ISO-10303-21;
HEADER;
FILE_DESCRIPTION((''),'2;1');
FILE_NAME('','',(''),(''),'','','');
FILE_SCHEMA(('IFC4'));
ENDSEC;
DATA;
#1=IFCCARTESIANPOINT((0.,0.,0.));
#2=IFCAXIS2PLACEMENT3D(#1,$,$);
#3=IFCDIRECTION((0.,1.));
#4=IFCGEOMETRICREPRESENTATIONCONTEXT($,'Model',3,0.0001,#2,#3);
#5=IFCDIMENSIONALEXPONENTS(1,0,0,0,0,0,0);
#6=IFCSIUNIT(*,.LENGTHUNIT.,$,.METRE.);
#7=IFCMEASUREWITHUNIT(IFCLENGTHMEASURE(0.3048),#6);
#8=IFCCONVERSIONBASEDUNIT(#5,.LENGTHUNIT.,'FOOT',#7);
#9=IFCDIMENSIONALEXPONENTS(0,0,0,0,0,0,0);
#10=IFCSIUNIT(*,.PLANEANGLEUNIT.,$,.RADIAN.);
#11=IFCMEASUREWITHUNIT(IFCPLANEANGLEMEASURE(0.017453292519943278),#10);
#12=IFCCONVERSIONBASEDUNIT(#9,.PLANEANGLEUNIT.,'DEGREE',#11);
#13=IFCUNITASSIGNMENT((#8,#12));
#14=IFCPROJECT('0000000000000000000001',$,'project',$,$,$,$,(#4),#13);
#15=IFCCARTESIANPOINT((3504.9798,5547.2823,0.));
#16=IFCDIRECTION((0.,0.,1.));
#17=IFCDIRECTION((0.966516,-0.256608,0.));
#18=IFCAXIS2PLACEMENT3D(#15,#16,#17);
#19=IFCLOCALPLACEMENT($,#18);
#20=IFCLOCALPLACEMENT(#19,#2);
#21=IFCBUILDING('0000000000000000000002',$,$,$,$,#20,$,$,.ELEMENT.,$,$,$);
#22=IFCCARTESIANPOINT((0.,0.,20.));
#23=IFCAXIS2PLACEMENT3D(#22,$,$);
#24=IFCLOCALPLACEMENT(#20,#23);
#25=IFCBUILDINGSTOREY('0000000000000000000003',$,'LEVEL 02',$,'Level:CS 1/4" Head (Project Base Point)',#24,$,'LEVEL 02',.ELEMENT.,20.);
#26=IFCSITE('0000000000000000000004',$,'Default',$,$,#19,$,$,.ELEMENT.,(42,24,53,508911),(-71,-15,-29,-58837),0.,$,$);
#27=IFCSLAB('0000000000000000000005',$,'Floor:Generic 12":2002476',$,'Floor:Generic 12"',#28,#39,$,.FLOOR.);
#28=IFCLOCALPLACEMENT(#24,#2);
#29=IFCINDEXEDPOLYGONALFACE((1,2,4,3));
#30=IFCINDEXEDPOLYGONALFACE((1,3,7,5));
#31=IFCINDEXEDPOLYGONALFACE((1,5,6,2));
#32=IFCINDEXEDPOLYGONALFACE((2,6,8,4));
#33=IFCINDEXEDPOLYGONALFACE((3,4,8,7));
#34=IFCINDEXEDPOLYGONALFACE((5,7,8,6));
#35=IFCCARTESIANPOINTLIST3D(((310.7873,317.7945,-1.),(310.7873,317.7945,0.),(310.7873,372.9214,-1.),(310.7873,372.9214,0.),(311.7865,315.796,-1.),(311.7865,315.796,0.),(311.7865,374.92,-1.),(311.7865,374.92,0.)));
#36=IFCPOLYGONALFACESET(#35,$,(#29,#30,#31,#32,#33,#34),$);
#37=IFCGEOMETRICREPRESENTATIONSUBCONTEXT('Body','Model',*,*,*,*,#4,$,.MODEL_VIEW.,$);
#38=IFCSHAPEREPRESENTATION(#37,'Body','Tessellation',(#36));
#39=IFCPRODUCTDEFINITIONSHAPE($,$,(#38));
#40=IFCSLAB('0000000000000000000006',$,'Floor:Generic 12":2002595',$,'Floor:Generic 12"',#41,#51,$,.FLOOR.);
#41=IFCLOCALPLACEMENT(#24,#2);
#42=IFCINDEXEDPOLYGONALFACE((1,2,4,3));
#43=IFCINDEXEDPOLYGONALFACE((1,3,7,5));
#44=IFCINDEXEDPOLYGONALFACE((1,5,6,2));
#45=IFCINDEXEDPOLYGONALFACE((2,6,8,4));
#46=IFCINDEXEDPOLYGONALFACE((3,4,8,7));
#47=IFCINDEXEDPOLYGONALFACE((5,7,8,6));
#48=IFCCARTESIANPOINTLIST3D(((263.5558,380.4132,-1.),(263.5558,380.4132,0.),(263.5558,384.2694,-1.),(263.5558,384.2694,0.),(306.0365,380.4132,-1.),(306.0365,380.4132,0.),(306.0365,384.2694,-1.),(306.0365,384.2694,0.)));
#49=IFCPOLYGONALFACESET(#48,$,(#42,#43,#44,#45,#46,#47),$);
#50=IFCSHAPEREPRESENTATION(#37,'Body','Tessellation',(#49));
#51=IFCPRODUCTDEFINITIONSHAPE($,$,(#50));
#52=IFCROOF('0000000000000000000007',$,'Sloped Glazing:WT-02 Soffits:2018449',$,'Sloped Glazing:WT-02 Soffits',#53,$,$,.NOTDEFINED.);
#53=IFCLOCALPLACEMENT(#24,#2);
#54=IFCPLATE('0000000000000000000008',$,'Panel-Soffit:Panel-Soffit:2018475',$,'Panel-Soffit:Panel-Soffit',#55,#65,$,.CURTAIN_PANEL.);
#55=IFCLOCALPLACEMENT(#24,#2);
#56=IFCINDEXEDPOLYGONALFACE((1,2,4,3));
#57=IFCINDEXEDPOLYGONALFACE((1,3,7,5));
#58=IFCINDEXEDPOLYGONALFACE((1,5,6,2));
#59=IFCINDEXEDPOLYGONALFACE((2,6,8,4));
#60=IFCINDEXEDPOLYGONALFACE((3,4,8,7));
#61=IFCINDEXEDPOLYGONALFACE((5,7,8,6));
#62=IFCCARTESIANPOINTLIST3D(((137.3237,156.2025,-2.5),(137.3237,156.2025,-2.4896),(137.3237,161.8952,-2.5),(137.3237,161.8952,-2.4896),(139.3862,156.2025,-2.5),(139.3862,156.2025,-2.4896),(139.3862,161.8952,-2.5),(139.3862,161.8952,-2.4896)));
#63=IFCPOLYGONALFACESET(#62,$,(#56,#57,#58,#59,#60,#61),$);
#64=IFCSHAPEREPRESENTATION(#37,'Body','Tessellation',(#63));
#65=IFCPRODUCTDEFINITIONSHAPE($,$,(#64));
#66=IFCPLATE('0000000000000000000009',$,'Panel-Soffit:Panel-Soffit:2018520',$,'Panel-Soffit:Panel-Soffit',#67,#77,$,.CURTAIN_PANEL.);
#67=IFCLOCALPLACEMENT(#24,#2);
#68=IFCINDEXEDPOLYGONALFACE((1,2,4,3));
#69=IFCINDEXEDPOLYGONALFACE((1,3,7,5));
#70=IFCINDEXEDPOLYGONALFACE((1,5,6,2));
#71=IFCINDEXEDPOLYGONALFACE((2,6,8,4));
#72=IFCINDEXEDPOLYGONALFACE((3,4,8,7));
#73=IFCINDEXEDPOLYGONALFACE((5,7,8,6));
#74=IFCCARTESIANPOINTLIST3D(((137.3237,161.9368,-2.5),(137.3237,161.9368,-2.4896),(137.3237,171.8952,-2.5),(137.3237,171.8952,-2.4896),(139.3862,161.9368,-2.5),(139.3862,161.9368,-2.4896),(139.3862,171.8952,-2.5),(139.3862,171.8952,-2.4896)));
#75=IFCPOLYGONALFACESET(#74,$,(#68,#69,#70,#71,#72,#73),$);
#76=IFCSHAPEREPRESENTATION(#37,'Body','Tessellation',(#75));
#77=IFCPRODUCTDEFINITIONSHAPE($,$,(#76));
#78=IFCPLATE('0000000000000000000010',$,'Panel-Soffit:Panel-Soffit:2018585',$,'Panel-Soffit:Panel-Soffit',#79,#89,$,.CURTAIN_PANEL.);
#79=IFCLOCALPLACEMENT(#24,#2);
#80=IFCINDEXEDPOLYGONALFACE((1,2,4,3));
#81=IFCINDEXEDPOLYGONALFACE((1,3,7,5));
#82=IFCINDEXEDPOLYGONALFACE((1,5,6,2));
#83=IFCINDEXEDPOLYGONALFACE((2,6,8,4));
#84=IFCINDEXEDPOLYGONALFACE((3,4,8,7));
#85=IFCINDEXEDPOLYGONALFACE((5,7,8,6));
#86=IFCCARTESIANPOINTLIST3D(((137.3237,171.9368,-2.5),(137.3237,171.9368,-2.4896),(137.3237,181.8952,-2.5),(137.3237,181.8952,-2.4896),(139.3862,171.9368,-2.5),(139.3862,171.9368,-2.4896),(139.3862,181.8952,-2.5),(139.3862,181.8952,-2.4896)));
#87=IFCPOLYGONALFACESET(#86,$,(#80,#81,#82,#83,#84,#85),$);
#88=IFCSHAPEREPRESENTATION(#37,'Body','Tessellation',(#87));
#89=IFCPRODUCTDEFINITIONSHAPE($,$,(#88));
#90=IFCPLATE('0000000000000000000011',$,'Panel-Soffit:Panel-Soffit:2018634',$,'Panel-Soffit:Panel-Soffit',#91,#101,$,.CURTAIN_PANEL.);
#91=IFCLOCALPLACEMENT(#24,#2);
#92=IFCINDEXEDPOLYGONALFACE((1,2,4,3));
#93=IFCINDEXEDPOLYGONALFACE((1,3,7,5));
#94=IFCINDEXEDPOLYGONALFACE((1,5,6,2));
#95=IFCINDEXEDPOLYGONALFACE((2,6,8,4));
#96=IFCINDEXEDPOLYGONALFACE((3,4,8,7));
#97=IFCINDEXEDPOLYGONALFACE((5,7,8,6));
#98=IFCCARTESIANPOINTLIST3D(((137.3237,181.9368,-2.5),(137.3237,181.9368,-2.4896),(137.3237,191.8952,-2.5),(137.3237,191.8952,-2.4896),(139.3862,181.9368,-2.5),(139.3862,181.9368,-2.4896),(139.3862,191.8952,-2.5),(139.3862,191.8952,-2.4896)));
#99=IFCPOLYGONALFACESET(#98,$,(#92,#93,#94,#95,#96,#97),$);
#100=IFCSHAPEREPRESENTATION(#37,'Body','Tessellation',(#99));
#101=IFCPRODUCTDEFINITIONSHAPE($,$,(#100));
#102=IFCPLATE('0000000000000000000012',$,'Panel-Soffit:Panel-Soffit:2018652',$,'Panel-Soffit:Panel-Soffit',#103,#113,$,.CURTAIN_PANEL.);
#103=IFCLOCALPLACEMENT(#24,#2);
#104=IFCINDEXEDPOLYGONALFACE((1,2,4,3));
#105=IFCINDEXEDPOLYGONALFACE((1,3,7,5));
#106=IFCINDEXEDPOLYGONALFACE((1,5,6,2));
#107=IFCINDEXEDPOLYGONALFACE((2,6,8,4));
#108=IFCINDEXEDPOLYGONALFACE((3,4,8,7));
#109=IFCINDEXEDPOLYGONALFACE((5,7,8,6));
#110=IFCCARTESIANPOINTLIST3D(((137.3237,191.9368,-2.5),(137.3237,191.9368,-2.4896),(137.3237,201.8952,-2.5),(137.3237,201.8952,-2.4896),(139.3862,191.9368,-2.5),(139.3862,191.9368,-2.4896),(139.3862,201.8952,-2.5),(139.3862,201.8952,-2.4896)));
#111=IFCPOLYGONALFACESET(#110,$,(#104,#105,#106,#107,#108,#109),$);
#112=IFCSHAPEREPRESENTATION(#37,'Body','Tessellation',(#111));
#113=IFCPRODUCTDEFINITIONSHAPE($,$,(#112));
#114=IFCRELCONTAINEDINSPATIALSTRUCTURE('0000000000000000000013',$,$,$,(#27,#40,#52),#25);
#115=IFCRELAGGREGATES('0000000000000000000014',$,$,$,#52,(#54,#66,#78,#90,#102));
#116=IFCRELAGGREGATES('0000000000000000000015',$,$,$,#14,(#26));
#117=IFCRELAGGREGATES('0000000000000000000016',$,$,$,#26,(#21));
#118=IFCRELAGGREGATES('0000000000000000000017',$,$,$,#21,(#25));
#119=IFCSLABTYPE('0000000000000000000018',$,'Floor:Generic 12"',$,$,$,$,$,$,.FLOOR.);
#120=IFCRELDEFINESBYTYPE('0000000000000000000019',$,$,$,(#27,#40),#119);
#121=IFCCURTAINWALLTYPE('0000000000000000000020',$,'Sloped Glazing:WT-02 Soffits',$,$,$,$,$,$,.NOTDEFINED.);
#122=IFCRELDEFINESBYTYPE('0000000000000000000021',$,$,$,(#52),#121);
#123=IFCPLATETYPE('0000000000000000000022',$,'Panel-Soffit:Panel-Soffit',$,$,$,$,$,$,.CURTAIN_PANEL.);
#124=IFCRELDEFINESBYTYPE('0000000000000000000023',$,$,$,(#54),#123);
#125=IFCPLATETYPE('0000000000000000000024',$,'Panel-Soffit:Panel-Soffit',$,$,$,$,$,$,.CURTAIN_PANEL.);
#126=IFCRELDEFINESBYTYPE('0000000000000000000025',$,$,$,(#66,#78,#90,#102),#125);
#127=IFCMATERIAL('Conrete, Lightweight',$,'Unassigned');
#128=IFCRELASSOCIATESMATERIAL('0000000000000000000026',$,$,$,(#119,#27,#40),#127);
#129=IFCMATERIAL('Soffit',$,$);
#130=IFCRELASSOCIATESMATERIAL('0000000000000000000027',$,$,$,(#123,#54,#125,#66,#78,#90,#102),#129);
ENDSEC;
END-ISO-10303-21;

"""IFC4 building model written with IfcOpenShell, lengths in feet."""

from ifc_helpers import new_model, entity, si_unit, converted_unit, direction, frame, origin, place, context, subcontext, project, spatial, indexed_curve, outline, extrude, source, transform, mapped, material, type_object, type_shapes, element, aggregate, save


model = new_model("IFC4")

# Units and contexts
model_context = context("Model", 3, precision=0.0001, world=origin(), true_north=direction((0.0, 1.0)))
body_context = subcontext(model_context, "Body", "Model", "MODEL_VIEW")
ifc_project = project(units=[converted_unit("LENGTHUNIT", "FOOT", entity("IfcLengthMeasure", 0.3048), si_unit("LENGTHUNIT", "METRE"), dimensions=[1, 0, 0, 0, 0, 0, 0]), converted_unit("PLANEANGLEUNIT", "DEGREE", entity("IfcPlaneAngleMeasure", 0.017453292519943278), si_unit("PLANEANGLEUNIT", "RADIAN"), dimensions=[0, 0, 0, 0, 0, 0, 0])], contexts=[model_context])

# Site, building, storey
site_placement = place(None, frame((3504.9798, 5547.2823, 0.0), z_axis=(0.0, 0.0, 1.0), x_axis=(0.966516, -0.256608, 0.0)))
site = spatial("IfcSite", under=ifc_project, at=site_placement, Name="Default", CompositionType="ELEMENT", RefLatitude=(42, 24, 53, 508911), RefLongitude=(-71, -15, -29, -58837), RefElevation=0.0)
building_placement = place(site_placement, origin())
building = spatial("IfcBuilding", under=site, at=building_placement, CompositionType="ELEMENT")
storey_placement = place(building_placement, frame((0.0, 0.0, 20.0)))
storey = spatial("IfcBuildingStorey", under=building, at=storey_placement, Name="LEVEL 02", ObjectType="Level:CS 1/4\" Head (Project Base Point)", LongName="LEVEL 02", CompositionType="ELEMENT", Elevation=20.0)

# Shared definitions
curtain_wall_type_1 = type_object("IfcCurtainWallType", Name="Sloped Glazing:WT-02 Soffits", PredefinedType="NOTDEFINED")
ifc_material_1 = material(Name="Soffit")

# Shared definitions
ifc_material_2 = material(Name="Conrete, Lightweight", Category="Unassigned")
slab_type = type_object("IfcSlabType", Name="Floor:Generic 12\"", PredefinedType="FLOOR", material=ifc_material_2)

# Slabs
slab_1_placement = place(storey_placement, origin())
element("IfcSlab", 1, at=slab_1_placement, inside=storey, type_object=slab_type, material=ifc_material_2, Name="Floor:Generic 12\":2002476", ObjectType="Floor:Generic 12\"", PredefinedType="FLOOR", context=body_context, shape_type="SweptSolid", body=[
    extrude(outline(indexed_curve([(-27.5634, -0.4996), (27.5634, -0.4996), (29.562, 0.4996), (-29.562, 0.4996), (-27.5634, -0.4996)], self_intersect=False)), frame((311.2869, 345.358, 0.0), z_axis=(0.0, 0.0, -1.0), x_axis=(0.0, 1.0, 0.0)), (0.0, 0.0, 1.0), 1.0),
])
slab_2_placement = place(storey_placement, origin())
element("IfcSlab", 2, at=slab_2_placement, inside=storey, type_object=slab_type, material=ifc_material_2, Name="Floor:Generic 12\":2002595", ObjectType="Floor:Generic 12\"", PredefinedType="FLOOR", context=body_context, shape_type="SweptSolid", body=[
    extrude(outline(indexed_curve([(-1.9281, -21.2404), (1.9281, -21.2404), (1.9281, 21.2404), (-1.9281, 21.2404), (-1.9281, -21.2404)], self_intersect=False)), frame((284.7962, 382.3413, 0.0), z_axis=(0.0, 0.0, -1.0), x_axis=(0.0, 1.0, 0.0)), (0.0, 0.0, 1.0), 1.0),
])

# Roof, plates
roof_1_placement = place(storey_placement, frame((0.0, 0.0, -20.0)))
roof_1 = element("IfcRoof", 3, at=roof_1_placement, inside=storey, type_object=curtain_wall_type_1, Name="Sloped Glazing:WT-02 Soffits:2018449", ObjectType="Sloped Glazing:WT-02 Soffits", PredefinedType="NOTDEFINED")
plate_type_1 = type_object("IfcPlateType", Name="Panel-Soffit:Panel-Soffit", PredefinedType="CURTAIN_PANEL", material=ifc_material_1)
shared_shape_1 = source(origin(), body_context, "Body", "SweptSolid", [
    extrude(outline(indexed_curve([(-0.0052, -1.0313), (0.0052, -1.0313), (0.0052, 1.0313), (-0.0052, 1.0313), (-0.0052, -1.0313)], self_intersect=False)), frame((0.0, -0.0052, 0.0208), z_axis=(0.0, 0.0, 1.0), x_axis=(0.0, -1.0, 0.0)), (0.0, 0.0, 1.0), 5.6927),
])
type_shapes(plate_type_1, [shared_shape_1])
plate_1_placement = place(roof_1_placement, frame((138.355, 156.1816, 17.5), z_axis=(0.0, 1.0, 0.0), x_axis=(1.0, 0.0, 0.0)))
plate_1 = element("IfcPlate", 4, at=plate_1_placement, type_object=plate_type_1, material=ifc_material_1, Name="Panel-Soffit:Panel-Soffit:2018475", ObjectType="Panel-Soffit:Panel-Soffit", PredefinedType="CURTAIN_PANEL", context=body_context, shape_type="MappedRepresentation", body=[
    mapped(shared_shape_1, transform((0.0, 0.0, 0.0), scale=1.0)),
])
plate_type_2 = type_object("IfcPlateType", Name="Panel-Soffit:Panel-Soffit", PredefinedType="CURTAIN_PANEL", material=ifc_material_1)
shared_shape_2 = source(origin(), body_context, "Body", "SweptSolid", [
    extrude(outline(indexed_curve([(-0.0052, -1.0313), (0.0052, -1.0313), (0.0052, 1.0313), (-0.0052, 1.0313), (-0.0052, -1.0313)], self_intersect=False)), frame((0.0, -0.0052, 0.0208), z_axis=(0.0, 0.0, 1.0), x_axis=(0.0, -1.0, 0.0)), (0.0, 0.0, 1.0), 9.9583),
])
type_shapes(plate_type_2, [shared_shape_2])
plate_2_placement = place(roof_1_placement, frame((138.355, 161.916, 17.5), z_axis=(0.0, 1.0, 0.0), x_axis=(1.0, 0.0, 0.0)))
plate_2 = element("IfcPlate", 5, at=plate_2_placement, type_object=plate_type_2, material=ifc_material_1, Name="Panel-Soffit:Panel-Soffit:2018520", ObjectType="Panel-Soffit:Panel-Soffit", PredefinedType="CURTAIN_PANEL", context=body_context, shape_type="MappedRepresentation", body=[
    mapped(shared_shape_2, transform((0.0, 0.0, 0.0), scale=1.0)),
])
plate_3_placement = place(roof_1_placement, frame((138.355, 171.916, 17.5), z_axis=(0.0, 1.0, 0.0), x_axis=(1.0, 0.0, 0.0)))
plate_3 = element("IfcPlate", 6, at=plate_3_placement, type_object=plate_type_2, material=ifc_material_1, Name="Panel-Soffit:Panel-Soffit:2018585", ObjectType="Panel-Soffit:Panel-Soffit", PredefinedType="CURTAIN_PANEL", context=body_context, shape_type="MappedRepresentation", body=[
    mapped(shared_shape_2, transform((0.0, 0.0, 0.0), scale=1.0)),
])
plate_4_placement = place(roof_1_placement, frame((138.355, 181.916, 17.5), z_axis=(0.0, 1.0, 0.0), x_axis=(1.0, 0.0, 0.0)))
plate_4 = element("IfcPlate", 7, at=plate_4_placement, type_object=plate_type_2, material=ifc_material_1, Name="Panel-Soffit:Panel-Soffit:2018634", ObjectType="Panel-Soffit:Panel-Soffit", PredefinedType="CURTAIN_PANEL", context=body_context, shape_type="MappedRepresentation", body=[
    mapped(shared_shape_2, transform((0.0, 0.0, 0.0), scale=1.0)),
])
plate_5_placement = place(roof_1_placement, frame((138.355, 191.916, 17.5), z_axis=(0.0, 1.0, 0.0), x_axis=(1.0, 0.0, 0.0)))
plate_5 = element("IfcPlate", 8, at=plate_5_placement, type_object=plate_type_2, material=ifc_material_1, Name="Panel-Soffit:Panel-Soffit:2018652", ObjectType="Panel-Soffit:Panel-Soffit", PredefinedType="CURTAIN_PANEL", context=body_context, shape_type="MappedRepresentation", body=[
    mapped(shared_shape_2, transform((0.0, 0.0, 0.0), scale=1.0)),
])
aggregate(roof_1, [plate_1, plate_2, plate_3, plate_4, plate_5])

save(model, "model.ifc")
